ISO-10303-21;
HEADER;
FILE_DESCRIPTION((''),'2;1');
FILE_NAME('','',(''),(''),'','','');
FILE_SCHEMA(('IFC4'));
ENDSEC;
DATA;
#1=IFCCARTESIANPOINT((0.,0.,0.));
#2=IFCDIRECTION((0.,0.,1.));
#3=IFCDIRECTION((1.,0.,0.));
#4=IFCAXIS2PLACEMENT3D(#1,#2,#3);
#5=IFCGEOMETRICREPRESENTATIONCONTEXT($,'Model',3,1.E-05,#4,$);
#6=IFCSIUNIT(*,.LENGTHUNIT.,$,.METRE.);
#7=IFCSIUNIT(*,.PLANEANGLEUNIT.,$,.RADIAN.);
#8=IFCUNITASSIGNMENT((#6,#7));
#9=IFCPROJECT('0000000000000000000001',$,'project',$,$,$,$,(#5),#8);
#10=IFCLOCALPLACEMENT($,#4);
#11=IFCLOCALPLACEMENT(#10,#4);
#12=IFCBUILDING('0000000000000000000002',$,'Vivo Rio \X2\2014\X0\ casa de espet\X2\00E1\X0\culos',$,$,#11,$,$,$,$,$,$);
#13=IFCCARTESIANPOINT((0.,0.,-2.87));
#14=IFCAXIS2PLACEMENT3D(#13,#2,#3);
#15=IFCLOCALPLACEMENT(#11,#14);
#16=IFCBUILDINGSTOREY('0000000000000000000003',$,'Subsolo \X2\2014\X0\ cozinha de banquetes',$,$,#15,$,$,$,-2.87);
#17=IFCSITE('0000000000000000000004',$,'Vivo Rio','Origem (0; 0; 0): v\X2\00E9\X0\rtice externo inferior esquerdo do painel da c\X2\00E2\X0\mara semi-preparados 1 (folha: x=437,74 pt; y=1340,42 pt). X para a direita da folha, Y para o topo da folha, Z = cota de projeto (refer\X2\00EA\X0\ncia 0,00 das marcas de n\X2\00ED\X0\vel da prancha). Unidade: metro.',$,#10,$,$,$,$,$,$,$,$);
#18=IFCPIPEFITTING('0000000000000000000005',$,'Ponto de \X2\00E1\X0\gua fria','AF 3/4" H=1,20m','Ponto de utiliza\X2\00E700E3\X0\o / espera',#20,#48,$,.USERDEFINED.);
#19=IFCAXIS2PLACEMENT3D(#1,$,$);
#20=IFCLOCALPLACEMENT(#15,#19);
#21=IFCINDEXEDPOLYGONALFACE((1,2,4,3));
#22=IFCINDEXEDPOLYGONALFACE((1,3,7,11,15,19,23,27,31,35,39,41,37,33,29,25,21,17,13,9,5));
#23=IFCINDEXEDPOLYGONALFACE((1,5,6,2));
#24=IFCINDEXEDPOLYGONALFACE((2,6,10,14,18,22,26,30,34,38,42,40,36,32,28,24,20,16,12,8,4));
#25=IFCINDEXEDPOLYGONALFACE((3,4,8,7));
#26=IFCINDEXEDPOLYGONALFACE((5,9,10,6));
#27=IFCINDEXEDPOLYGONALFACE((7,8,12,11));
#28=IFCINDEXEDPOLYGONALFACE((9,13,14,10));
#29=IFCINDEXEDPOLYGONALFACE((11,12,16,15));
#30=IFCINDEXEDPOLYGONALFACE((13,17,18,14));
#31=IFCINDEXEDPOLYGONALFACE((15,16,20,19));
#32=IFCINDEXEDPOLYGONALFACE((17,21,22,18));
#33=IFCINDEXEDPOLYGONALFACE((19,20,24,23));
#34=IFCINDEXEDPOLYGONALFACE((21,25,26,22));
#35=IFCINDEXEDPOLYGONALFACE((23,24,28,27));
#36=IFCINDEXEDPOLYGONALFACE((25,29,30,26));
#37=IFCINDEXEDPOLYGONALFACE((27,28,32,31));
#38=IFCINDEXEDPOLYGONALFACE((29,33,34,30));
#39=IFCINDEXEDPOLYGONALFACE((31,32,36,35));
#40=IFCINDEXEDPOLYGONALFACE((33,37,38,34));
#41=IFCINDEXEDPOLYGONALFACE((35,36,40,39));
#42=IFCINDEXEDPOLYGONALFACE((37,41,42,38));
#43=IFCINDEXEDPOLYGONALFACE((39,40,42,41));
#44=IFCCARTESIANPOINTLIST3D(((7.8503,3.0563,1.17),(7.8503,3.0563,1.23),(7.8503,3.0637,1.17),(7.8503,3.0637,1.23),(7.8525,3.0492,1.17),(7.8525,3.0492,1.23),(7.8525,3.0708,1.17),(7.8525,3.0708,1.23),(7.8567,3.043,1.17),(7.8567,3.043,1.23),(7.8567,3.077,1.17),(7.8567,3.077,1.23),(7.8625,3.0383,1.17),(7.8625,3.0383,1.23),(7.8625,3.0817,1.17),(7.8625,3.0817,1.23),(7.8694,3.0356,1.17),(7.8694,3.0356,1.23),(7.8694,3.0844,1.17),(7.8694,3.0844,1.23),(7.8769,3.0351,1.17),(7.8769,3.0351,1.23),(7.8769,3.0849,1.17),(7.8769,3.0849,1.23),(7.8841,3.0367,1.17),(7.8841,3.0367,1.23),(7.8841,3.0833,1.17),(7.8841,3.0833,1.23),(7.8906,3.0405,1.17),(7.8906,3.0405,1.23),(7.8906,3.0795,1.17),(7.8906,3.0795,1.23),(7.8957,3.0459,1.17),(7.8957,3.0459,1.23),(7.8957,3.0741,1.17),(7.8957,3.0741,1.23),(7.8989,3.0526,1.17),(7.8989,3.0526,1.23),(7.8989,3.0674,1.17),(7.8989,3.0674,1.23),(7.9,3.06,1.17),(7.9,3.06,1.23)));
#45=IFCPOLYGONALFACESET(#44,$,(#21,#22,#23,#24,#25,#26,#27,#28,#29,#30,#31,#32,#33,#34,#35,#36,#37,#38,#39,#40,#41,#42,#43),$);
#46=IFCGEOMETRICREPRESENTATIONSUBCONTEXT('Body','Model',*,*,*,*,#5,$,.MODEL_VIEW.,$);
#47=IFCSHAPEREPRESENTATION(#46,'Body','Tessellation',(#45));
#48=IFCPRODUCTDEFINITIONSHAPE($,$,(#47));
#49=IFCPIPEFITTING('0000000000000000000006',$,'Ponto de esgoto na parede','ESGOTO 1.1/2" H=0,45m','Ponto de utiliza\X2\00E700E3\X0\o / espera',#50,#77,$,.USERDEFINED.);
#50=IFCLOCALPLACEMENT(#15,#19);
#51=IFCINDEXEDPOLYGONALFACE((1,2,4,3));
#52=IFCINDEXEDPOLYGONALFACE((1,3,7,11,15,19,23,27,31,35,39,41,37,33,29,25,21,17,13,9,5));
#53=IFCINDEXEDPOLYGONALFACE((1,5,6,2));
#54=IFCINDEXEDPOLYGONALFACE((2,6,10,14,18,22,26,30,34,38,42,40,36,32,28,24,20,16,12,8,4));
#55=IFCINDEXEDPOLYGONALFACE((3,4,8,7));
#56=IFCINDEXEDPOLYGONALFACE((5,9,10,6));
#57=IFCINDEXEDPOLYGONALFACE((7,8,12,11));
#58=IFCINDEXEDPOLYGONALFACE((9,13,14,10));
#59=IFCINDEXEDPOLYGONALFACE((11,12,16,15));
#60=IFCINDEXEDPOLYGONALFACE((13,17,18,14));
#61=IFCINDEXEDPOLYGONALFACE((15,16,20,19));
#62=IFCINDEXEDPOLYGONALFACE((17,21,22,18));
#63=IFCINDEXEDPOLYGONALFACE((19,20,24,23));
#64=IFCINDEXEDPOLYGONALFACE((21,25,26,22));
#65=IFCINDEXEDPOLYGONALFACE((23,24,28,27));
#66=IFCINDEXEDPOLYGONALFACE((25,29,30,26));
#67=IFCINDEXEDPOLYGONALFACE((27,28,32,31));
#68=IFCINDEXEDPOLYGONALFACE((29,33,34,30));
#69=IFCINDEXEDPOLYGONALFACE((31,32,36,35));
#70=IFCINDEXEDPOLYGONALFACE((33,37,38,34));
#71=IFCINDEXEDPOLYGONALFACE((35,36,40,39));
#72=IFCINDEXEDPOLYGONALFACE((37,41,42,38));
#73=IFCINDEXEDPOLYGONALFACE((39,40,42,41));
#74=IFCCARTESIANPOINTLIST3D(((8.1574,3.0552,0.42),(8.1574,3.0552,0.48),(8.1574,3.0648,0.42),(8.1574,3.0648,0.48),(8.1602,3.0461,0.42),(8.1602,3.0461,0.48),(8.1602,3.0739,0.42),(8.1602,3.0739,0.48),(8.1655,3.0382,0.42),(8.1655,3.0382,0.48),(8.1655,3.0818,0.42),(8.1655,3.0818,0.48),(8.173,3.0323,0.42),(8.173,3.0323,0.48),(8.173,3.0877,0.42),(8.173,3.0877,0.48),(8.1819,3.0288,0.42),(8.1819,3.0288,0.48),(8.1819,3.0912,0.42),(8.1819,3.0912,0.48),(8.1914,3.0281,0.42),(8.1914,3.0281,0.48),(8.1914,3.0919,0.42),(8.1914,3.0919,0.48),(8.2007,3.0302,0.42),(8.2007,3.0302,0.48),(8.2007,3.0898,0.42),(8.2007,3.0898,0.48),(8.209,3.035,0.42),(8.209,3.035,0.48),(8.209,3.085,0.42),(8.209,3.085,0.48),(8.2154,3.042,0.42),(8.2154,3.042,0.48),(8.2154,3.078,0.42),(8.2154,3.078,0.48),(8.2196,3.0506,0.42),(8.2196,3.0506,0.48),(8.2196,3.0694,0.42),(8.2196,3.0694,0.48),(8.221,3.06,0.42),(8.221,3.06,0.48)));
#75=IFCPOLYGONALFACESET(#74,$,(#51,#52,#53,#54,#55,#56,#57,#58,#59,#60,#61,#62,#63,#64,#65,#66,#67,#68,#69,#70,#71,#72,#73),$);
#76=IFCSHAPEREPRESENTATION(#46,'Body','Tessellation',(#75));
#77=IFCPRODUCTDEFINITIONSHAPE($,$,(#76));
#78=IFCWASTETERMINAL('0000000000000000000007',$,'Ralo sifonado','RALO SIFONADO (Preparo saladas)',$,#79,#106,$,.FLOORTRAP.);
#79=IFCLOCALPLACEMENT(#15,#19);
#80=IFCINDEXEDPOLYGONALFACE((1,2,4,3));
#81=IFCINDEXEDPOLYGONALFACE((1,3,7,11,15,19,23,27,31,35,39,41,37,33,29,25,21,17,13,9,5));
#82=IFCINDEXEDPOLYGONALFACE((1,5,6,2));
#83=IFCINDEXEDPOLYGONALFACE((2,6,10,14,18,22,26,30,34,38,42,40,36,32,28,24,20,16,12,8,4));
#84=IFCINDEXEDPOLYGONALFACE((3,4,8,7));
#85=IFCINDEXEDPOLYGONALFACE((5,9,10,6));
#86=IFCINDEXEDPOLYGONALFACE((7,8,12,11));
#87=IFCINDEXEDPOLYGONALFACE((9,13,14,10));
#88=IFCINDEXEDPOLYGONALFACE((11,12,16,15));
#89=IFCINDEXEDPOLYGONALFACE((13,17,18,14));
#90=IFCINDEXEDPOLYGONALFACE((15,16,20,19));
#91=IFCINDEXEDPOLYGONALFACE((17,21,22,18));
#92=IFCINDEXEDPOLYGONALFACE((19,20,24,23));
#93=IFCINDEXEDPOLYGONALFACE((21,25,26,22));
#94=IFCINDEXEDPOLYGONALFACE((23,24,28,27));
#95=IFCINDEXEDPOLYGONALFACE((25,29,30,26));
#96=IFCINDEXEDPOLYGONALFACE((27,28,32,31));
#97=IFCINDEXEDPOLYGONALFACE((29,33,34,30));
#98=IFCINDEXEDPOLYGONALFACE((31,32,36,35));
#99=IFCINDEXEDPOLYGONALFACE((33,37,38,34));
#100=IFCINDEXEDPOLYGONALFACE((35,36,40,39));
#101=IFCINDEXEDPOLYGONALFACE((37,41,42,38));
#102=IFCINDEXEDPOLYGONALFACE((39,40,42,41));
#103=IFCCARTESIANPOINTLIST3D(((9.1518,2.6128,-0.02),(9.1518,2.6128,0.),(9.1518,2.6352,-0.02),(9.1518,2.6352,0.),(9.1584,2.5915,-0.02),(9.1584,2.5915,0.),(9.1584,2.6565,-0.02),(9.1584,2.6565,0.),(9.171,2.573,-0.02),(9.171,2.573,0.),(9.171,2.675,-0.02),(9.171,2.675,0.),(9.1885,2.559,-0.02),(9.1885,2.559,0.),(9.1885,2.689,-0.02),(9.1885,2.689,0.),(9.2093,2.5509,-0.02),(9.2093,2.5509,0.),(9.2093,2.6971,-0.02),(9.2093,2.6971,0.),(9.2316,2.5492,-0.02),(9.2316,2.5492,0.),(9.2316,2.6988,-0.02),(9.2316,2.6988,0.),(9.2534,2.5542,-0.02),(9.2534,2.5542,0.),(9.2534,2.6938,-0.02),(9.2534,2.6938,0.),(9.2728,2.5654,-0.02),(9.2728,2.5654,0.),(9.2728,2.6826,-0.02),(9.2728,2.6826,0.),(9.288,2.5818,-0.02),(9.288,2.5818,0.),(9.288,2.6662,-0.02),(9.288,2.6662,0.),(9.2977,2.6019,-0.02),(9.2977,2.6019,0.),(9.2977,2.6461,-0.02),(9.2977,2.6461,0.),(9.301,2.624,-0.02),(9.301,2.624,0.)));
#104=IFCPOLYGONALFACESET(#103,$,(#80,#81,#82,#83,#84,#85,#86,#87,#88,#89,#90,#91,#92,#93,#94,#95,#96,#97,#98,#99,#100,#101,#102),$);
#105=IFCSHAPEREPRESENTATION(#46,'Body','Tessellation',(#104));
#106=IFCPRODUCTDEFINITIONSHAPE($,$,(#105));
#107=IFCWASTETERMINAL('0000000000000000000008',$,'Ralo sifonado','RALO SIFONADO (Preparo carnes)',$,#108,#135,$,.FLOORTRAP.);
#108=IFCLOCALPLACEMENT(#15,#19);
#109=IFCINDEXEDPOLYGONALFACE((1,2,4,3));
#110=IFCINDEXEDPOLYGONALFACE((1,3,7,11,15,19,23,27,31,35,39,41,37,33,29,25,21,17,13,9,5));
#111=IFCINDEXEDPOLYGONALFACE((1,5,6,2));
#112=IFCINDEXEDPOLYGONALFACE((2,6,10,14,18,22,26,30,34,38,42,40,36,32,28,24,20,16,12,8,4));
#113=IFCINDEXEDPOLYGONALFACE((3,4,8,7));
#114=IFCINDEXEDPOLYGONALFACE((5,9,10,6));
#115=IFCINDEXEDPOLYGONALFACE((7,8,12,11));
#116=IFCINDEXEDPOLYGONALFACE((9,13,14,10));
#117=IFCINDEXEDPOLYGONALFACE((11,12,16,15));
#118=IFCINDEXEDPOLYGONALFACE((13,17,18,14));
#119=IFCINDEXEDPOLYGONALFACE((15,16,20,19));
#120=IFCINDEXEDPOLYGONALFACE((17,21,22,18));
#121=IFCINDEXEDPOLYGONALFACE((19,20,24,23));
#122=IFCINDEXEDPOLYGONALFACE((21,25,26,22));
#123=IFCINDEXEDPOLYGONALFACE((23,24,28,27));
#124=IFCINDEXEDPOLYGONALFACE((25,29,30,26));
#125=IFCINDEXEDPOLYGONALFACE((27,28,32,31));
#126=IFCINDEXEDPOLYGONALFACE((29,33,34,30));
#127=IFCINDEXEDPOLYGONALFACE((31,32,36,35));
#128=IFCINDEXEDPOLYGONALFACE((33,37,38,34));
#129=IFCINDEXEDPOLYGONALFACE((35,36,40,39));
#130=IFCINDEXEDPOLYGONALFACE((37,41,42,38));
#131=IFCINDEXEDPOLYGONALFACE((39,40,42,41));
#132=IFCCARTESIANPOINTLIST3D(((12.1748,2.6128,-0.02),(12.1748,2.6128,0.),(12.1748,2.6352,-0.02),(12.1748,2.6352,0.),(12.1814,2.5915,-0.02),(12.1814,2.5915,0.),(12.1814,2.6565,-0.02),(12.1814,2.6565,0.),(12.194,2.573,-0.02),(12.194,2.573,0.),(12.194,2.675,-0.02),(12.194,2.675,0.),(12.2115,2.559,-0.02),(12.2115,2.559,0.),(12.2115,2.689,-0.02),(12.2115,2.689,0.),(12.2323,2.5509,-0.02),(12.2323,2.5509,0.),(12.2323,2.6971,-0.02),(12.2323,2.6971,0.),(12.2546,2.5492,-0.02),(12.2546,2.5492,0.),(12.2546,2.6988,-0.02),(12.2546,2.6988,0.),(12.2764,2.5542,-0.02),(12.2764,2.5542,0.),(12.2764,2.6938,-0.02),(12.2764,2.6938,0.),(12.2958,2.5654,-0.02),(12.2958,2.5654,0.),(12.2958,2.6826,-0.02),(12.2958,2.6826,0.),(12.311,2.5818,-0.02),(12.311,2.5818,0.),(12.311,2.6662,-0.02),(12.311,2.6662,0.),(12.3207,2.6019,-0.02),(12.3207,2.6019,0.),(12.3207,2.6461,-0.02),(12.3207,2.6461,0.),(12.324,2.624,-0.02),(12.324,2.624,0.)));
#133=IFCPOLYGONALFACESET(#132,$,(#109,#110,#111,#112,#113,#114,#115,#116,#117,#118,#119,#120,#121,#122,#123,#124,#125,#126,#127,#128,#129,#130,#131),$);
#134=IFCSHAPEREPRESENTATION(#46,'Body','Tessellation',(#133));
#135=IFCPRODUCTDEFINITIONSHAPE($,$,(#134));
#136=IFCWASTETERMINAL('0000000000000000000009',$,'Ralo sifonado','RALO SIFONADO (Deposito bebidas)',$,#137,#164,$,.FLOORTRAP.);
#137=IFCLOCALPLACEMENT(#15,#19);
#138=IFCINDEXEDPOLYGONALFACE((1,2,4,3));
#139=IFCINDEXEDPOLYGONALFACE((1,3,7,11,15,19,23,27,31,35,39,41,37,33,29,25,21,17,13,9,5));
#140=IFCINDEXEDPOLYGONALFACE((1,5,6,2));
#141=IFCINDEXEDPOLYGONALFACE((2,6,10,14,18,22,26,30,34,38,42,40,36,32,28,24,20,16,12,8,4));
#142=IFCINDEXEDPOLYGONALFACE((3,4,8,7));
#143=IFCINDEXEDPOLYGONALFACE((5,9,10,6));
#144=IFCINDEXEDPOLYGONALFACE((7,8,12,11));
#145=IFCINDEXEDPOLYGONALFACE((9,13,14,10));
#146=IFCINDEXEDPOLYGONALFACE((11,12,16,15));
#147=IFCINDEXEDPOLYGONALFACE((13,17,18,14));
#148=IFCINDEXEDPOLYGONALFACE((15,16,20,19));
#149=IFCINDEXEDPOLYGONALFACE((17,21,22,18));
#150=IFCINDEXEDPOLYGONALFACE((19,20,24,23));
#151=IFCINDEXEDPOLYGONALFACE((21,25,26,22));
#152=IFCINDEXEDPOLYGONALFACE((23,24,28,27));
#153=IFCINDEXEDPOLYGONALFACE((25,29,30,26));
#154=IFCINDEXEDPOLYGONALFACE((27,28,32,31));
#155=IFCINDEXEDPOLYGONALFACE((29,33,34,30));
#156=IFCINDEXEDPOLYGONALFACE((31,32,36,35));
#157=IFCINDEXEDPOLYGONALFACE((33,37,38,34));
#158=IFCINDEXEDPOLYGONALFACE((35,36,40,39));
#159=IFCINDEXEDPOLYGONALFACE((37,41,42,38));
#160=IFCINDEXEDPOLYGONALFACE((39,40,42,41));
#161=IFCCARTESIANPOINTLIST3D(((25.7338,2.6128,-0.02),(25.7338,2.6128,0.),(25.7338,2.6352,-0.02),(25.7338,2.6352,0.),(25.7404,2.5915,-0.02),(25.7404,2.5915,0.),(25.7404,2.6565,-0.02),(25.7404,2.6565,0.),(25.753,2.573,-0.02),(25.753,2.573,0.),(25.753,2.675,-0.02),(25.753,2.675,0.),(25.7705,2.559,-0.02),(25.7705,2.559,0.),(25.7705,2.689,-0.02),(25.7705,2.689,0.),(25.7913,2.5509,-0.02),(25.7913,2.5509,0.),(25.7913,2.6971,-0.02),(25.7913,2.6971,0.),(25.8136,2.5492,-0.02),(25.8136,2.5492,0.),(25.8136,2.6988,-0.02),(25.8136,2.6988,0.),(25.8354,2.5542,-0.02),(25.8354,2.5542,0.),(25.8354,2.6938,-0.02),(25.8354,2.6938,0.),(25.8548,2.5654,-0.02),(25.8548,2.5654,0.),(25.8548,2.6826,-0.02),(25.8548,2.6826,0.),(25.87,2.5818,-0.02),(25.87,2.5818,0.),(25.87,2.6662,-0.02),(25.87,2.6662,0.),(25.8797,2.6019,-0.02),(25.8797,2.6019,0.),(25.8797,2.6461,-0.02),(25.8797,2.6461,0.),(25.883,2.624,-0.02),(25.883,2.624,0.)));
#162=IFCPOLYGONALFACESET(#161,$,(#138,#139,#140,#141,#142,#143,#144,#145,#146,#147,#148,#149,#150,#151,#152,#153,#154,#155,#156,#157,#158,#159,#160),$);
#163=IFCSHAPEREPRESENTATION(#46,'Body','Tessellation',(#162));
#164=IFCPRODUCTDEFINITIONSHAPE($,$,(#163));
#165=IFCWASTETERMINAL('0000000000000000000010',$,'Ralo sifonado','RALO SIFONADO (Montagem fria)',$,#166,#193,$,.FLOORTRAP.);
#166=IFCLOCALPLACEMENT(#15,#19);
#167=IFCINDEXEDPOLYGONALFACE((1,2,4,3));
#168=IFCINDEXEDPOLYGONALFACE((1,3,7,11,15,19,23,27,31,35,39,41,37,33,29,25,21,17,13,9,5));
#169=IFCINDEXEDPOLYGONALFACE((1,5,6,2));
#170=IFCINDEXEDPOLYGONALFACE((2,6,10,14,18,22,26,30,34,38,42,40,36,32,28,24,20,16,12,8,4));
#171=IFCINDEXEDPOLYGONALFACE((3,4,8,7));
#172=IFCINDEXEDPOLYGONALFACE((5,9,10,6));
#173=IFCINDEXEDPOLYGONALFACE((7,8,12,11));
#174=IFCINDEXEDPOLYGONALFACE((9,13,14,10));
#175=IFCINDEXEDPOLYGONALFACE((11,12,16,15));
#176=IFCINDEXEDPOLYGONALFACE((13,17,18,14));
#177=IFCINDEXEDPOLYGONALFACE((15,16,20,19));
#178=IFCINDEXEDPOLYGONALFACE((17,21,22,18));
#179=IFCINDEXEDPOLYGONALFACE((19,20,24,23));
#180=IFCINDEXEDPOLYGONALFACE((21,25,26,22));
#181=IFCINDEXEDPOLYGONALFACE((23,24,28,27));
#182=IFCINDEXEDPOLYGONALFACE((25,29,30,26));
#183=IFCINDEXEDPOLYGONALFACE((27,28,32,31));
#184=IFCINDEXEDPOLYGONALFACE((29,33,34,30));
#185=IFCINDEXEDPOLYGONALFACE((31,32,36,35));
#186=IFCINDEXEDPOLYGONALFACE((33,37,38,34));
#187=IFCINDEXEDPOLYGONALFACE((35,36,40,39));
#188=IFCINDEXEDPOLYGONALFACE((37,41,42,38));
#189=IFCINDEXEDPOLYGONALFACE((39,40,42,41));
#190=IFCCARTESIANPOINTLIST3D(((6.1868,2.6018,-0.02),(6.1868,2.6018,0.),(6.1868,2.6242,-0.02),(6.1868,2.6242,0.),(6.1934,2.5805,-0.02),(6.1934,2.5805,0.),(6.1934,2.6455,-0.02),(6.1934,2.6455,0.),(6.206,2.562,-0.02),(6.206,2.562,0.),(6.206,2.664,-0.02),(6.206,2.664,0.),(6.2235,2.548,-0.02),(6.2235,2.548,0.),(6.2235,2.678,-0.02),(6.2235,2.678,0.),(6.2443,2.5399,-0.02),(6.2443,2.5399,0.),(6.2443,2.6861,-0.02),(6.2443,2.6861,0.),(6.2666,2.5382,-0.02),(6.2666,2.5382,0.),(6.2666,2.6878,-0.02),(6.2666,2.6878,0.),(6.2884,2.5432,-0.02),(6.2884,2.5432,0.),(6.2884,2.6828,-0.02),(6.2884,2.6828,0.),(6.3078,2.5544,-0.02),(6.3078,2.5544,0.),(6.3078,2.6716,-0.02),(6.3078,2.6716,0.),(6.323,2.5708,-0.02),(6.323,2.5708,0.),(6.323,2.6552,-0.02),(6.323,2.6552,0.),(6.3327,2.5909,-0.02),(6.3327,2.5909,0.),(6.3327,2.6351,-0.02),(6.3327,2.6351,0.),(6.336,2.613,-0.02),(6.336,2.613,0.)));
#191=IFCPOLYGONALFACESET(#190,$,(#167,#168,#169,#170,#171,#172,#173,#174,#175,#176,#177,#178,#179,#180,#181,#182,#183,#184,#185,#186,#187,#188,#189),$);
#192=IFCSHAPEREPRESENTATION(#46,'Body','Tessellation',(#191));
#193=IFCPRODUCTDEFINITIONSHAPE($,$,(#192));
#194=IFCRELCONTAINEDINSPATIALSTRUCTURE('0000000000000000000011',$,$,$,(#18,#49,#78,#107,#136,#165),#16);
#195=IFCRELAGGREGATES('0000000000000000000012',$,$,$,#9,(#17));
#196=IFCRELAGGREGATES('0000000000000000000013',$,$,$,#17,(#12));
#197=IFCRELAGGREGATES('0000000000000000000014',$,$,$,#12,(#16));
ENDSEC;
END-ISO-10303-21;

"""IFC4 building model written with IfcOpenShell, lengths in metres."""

from ifc_helpers import new_model, si_unit, frame, origin_with_axes, origin_2d, place, context, subcontext, project, spatial, circle, extrude, element, save


model = new_model("IFC4")

# Units and contexts
model_context = context("Model", 3, precision=1e-05, world=origin_with_axes())
body_context = subcontext(model_context, "Body", "Model", "MODEL_VIEW")
ifc_project = project(units=[si_unit("LENGTHUNIT", "METRE"), si_unit("PLANEANGLEUNIT", "RADIAN")], contexts=[model_context])

# Site, building, storey
site_placement = place(None, origin_with_axes())
site = spatial("IfcSite", under=ifc_project, at=site_placement, Name="Vivo Rio", Description="Origem (0; 0; 0): vértice externo inferior esquerdo do painel da câmara semi-preparados 1 (folha: x=437,74 pt; y=1340,42 pt). X para a direita da folha, Y para o topo da folha, Z = cota de projeto (referência 0,00 das marcas de nível da prancha). Unidade: metro.")
building_placement = place(site_placement, origin_with_axes())
building = spatial("IfcBuilding", under=site, at=building_placement, Name="Vivo Rio — casa de espetáculos")
storey_placement = place(building_placement, frame((0.0, 0.0, -2.87), z_axis=(0.0, 0.0, 1.0), x_axis=(1.0, 0.0, 0.0)))
storey = spatial("IfcBuildingStorey", under=building, at=storey_placement, Name="Subsolo — cozinha de banquetes", Elevation=-2.87)

# Pipe fittings
pipe_fitting_1_placement = place(storey_placement, origin_with_axes())
element("IfcPipeFitting", 1, at=pipe_fitting_1_placement, inside=storey, Name="Ponto de água fria", Description="AF 3/4\" H=1,20m", ObjectType="Ponto de utilização / espera", PredefinedType="USERDEFINED", context=body_context, shape_type="SweptSolid", body=[
    extrude(circle(Radius=0.025, at=origin_2d()), frame((7.875, 3.06, 1.17), z_axis=(0.0, 0.0, 1.0), x_axis=(1.0, 0.0, 0.0)), (0.0, 0.0, 1.0), 0.06),
])
pipe_fitting_2_placement = place(storey_placement, origin_with_axes())
element("IfcPipeFitting", 2, at=pipe_fitting_2_placement, inside=storey, Name="Ponto de esgoto na parede", Description="ESGOTO 1.1/2\" H=0,45m", ObjectType="Ponto de utilização / espera", PredefinedType="USERDEFINED", context=body_context, shape_type="SweptSolid", body=[
    extrude(circle(Radius=0.032, at=origin_2d()), frame((8.189, 3.06, 0.42), z_axis=(0.0, 0.0, 1.0), x_axis=(1.0, 0.0, 0.0)), (0.0, 0.0, 1.0), 0.06),
])

# Waste terminals
waste_terminal_1_placement = place(storey_placement, origin_with_axes())
element("IfcWasteTerminal", 3, at=waste_terminal_1_placement, inside=storey, Name="Ralo sifonado", Description="RALO SIFONADO (Preparo saladas)", PredefinedType="FLOORTRAP", context=body_context, shape_type="SweptSolid", body=[
    extrude(circle(Radius=0.075, at=origin_2d()), frame((9.226, 2.624, -0.02), z_axis=(0.0, 0.0, 1.0), x_axis=(1.0, 0.0, 0.0)), (0.0, 0.0, 1.0), 0.02),
])
waste_terminal_2_placement = place(storey_placement, origin_with_axes())
element("IfcWasteTerminal", 4, at=waste_terminal_2_placement, inside=storey, Name="Ralo sifonado", Description="RALO SIFONADO (Preparo carnes)", PredefinedType="FLOORTRAP", context=body_context, shape_type="SweptSolid", body=[
    extrude(circle(Radius=0.075, at=origin_2d()), frame((12.249, 2.624, -0.02), z_axis=(0.0, 0.0, 1.0), x_axis=(1.0, 0.0, 0.0)), (0.0, 0.0, 1.0), 0.02),
])
waste_terminal_3_placement = place(storey_placement, origin_with_axes())
element("IfcWasteTerminal", 5, at=waste_terminal_3_placement, inside=storey, Name="Ralo sifonado", Description="RALO SIFONADO (Deposito bebidas)", PredefinedType="FLOORTRAP", context=body_context, shape_type="SweptSolid", body=[
    extrude(circle(Radius=0.075, at=origin_2d()), frame((25.808, 2.624, -0.02), z_axis=(0.0, 0.0, 1.0), x_axis=(1.0, 0.0, 0.0)), (0.0, 0.0, 1.0), 0.02),
])
waste_terminal_4_placement = place(storey_placement, origin_with_axes())
element("IfcWasteTerminal", 6, at=waste_terminal_4_placement, inside=storey, Name="Ralo sifonado", Description="RALO SIFONADO (Montagem fria)", PredefinedType="FLOORTRAP", context=body_context, shape_type="SweptSolid", body=[
    extrude(circle(Radius=0.075, at=origin_2d()), frame((6.261, 2.613, -0.02), z_axis=(0.0, 0.0, 1.0), x_axis=(1.0, 0.0, 0.0)), (0.0, 0.0, 1.0), 0.02),
])

save(model, "model.ifc")
